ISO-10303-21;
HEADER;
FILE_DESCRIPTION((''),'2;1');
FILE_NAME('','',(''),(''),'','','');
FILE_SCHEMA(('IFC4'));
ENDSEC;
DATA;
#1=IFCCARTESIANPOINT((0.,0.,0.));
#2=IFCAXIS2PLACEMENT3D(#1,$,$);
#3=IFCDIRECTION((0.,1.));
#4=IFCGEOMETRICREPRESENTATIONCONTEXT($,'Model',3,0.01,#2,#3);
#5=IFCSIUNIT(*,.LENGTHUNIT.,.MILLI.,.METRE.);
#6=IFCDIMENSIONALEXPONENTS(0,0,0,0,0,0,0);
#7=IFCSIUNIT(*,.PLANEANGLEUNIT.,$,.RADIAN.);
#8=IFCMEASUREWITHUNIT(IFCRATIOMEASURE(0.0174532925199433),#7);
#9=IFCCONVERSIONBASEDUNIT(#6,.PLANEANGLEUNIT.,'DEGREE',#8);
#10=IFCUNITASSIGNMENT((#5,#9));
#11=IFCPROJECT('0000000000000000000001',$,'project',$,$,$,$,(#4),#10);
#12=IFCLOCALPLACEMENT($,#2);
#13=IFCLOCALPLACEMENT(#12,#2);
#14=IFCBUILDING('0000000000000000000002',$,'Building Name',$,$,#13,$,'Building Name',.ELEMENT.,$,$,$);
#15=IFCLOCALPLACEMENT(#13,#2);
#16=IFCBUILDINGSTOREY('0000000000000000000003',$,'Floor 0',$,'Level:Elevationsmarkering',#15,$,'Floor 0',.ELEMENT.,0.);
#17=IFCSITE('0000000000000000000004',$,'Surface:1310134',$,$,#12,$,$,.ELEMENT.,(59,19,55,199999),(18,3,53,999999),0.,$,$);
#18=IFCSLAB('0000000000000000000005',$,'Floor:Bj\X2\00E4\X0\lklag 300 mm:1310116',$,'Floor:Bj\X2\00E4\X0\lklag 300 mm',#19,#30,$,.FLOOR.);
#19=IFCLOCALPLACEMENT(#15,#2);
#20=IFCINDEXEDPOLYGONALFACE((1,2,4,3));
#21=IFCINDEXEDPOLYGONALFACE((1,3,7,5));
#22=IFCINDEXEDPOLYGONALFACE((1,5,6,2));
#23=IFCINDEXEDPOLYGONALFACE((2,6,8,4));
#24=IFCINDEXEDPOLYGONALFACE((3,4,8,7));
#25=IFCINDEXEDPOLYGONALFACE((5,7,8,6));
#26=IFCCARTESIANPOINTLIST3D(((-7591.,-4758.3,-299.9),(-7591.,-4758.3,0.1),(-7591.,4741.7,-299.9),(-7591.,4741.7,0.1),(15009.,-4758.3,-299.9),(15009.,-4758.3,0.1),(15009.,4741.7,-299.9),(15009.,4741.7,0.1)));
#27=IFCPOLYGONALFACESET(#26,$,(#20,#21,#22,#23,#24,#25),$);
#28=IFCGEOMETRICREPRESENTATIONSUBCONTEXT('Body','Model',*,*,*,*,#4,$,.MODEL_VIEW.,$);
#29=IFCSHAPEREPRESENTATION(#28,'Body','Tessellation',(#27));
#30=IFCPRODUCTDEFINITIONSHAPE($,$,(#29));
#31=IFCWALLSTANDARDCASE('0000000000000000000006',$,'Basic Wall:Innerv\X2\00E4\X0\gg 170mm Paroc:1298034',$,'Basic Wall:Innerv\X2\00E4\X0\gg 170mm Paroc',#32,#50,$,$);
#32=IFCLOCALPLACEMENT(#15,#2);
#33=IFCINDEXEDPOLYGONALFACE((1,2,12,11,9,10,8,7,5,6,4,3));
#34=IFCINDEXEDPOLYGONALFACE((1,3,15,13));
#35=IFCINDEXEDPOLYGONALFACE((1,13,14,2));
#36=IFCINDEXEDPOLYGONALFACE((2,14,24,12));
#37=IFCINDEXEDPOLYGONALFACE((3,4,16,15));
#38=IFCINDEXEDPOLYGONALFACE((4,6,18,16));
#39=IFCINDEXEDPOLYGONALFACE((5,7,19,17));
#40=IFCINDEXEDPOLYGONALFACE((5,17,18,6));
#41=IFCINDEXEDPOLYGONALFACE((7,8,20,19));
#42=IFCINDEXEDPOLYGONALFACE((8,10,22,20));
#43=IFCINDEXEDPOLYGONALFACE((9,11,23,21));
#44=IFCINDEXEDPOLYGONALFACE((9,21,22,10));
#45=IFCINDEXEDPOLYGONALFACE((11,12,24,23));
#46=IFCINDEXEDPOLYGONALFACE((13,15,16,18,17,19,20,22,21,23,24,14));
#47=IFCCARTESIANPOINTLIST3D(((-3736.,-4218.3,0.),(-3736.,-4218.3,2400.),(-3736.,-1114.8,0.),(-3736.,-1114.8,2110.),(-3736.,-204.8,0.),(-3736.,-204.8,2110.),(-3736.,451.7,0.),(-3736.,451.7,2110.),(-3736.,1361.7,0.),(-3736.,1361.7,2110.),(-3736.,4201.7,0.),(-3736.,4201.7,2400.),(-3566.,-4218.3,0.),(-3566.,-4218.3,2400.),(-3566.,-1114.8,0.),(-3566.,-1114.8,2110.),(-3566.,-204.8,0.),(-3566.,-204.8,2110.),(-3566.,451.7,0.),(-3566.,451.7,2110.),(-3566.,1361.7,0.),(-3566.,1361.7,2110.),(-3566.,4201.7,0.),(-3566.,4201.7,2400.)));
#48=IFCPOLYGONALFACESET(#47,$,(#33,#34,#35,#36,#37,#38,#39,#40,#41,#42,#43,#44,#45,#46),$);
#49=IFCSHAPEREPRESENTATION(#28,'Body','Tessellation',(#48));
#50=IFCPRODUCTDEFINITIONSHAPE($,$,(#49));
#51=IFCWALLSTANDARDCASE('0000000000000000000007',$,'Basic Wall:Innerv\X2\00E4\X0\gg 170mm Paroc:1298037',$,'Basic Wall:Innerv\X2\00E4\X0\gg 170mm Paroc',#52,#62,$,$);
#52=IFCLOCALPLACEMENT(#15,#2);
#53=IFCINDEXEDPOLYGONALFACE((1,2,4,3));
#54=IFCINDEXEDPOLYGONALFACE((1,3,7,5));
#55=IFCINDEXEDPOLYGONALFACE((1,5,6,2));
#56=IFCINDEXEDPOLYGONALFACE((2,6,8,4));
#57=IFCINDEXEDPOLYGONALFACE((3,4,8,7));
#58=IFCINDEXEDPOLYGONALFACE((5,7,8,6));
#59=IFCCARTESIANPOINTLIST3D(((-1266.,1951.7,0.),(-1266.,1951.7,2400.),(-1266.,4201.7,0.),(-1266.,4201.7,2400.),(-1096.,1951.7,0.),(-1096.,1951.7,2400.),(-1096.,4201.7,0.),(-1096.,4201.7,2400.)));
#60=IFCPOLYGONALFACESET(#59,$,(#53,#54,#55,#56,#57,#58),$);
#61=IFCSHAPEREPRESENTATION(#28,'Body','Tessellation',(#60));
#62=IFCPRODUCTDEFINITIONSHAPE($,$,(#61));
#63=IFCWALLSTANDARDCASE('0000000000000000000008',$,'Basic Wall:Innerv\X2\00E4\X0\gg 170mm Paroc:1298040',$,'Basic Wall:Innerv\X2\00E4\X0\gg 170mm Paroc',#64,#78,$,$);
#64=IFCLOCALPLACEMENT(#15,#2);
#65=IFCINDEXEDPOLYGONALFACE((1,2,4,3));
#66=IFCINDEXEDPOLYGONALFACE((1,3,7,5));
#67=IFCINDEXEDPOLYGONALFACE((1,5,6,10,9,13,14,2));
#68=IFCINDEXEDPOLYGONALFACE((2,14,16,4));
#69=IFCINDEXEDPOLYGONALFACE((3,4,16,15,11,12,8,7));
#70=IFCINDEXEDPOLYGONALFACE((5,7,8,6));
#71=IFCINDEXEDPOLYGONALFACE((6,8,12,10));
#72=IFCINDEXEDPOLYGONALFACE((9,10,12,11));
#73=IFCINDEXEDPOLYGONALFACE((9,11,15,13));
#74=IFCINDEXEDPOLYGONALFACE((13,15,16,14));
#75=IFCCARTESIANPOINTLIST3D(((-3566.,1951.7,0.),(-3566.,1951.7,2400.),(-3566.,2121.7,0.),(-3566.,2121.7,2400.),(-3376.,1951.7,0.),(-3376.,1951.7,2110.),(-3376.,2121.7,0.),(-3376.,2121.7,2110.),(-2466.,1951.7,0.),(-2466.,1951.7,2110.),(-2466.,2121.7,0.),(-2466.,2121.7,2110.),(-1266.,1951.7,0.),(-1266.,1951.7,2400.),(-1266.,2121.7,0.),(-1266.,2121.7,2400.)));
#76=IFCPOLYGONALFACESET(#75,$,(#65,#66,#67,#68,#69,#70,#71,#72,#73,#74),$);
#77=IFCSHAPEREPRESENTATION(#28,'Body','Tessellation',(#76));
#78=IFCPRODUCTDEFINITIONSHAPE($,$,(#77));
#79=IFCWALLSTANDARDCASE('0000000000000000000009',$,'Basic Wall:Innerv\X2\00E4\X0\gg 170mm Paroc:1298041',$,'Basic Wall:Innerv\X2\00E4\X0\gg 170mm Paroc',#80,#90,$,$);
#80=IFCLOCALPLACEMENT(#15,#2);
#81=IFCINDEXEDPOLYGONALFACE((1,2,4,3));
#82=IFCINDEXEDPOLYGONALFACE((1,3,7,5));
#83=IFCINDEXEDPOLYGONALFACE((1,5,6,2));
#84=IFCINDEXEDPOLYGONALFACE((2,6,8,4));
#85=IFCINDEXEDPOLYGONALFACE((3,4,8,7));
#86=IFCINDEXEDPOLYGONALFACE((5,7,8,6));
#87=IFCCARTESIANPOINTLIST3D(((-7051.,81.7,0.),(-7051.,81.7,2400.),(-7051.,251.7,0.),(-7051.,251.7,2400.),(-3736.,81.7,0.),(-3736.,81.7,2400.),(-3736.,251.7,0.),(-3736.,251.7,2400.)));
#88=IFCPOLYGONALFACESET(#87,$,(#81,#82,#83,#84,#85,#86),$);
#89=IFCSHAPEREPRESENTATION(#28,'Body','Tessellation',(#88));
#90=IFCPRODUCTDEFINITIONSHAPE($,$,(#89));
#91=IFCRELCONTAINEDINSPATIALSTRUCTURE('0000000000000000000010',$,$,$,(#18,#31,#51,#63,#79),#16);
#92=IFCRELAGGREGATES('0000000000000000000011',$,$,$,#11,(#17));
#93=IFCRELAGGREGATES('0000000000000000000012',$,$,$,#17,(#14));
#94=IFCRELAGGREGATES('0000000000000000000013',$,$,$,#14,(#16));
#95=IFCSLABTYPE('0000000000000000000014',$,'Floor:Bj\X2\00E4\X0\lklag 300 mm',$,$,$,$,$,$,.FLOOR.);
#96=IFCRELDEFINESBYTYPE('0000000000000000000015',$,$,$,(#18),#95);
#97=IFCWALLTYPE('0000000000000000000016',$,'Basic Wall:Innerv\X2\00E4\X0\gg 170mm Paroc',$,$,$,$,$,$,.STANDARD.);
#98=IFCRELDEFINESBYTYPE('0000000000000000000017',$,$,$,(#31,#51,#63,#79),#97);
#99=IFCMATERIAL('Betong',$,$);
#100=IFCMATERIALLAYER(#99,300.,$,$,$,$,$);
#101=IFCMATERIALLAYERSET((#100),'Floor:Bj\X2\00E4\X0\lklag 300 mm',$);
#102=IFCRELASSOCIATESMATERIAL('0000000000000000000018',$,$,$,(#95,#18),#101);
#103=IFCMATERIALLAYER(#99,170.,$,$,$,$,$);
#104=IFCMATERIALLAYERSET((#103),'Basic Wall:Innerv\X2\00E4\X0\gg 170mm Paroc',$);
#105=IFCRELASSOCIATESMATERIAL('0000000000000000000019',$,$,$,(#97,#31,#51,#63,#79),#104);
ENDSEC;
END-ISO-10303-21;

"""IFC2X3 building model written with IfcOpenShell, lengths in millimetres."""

from ifc_helpers import new_model, entity, si_unit, converted_unit, direction, frame, frame_2d, origin, place, context, subcontext, project, spatial, rectangle, extrude, material, layer, layer_set, layer_usage, type_object, element, save


model = new_model("IFC2X3")

# Units and contexts
model_context = context("Model", 3, precision=0.01, world=origin(), true_north=direction((0.0, 1.0)))
body_context = subcontext(model_context, "Body", "Model", "MODEL_VIEW")
ifc_project = project(units=[si_unit("LENGTHUNIT", "METRE", prefix="MILLI"), converted_unit("PLANEANGLEUNIT", "DEGREE", entity("IfcRatioMeasure", 0.0174532925199433), si_unit("PLANEANGLEUNIT", "RADIAN"), dimensions=[0, 0, 0, 0, 0, 0, 0])], contexts=[model_context])

# Site, building, storey
site_placement = place(None, origin())
site = spatial("IfcSite", under=ifc_project, at=site_placement, Name="Surface:1310134", CompositionType="ELEMENT", RefLatitude=(59, 19, 55, 199999), RefLongitude=(18, 3, 53, 999999), RefElevation=0.0)
building_placement = place(site_placement, origin())
building = spatial("IfcBuilding", under=site, at=building_placement, Name="Building Name", LongName="Building Name", CompositionType="ELEMENT")
storey_placement = place(building_placement, origin())
storey = spatial("IfcBuildingStorey", under=building, at=storey_placement, Name="Floor 0", ObjectType="Level:Elevationsmarkering", LongName="Floor 0", CompositionType="ELEMENT", Elevation=0.0)

# Slab
ifc_material_1 = material(Name="Betong")
ifc_layer_1 = layer(ifc_material_1, 300.0)
ifc_layer_set_1 = layer_set([ifc_layer_1], Name="Floor:Bjälklag 300 mm")
ifc_layer_usage_1 = layer_usage(ifc_layer_set_1, "AXIS3", "POSITIVE", 0.0)
slab_type = type_object("IfcSlabType", Name="Floor:Bjälklag 300 mm", PredefinedType="FLOOR", material=ifc_layer_set_1)
slab_placement = place(storey_placement, origin())
element("IfcSlab", 1, at=slab_placement, inside=storey, type_object=slab_type, material=ifc_layer_usage_1, Name="Floor:Bjälklag 300 mm:1310116", ObjectType="Floor:Bjälklag 300 mm", PredefinedType="FLOOR", context=body_context, shape_type="SweptSolid", body=[
    extrude(rectangle(XDim=9500.0, YDim=22600.0, at=frame_2d((0.0, 0.0), x_axis=(1.0, 0.0))), frame((3709.0, -8.3, 0.1), z_axis=(0.0, 0.0, -1.0), x_axis=(0.0, 1.0, 0.0)), (0.0, 0.0, 1.0), 300.0),
])

# Wall, openings
ifc_layer_2 = layer(ifc_material_1, 170.0)
ifc_layer_set_2 = layer_set([ifc_layer_2], Name="Basic Wall:Innervägg 170mm Paroc")
ifc_layer_usage_2 = layer_usage(ifc_layer_set_2, "AXIS2", "NEGATIVE", 85.0)
wall_type_1 = type_object("IfcWallType", Name="Basic Wall:Innervägg 170mm Paroc", PredefinedType="STANDARD", material=ifc_layer_set_2)
wall_1_placement = place(storey_placement, frame((-3651.0, 4201.7, 0.0), z_axis=(0.0, 0.0, 1.0), x_axis=(0.0, -1.0, 0.0)))
wall_1 = element("IfcWallStandardCase", 2, at=wall_1_placement, inside=storey, type_object=wall_type_1, material=ifc_layer_usage_2, Name="Basic Wall:Innervägg 170mm Paroc:1298034", ObjectType="Basic Wall:Innervägg 170mm Paroc", context=body_context, shape_type="SweptSolid", body=[
    extrude(rectangle(XDim=8420.0, YDim=170.0, at=frame_2d((4210.0, 0.0), x_axis=(-1.0, 0.0))), origin(), (0.0, 0.0, 1.0), 2400.0),
])
opening_1_placement = place(wall_1_placement, frame((3750.0, 85.0, 0.0)))
element("IfcOpeningElement", 3, at=opening_1_placement, cuts=wall_1, ObjectType="Opening", context=body_context, shape_type="SweptSolid", body=[
    extrude(rectangle(XDim=2110.0, YDim=910.0, at=frame_2d((1055.0, 455.0), x_axis=(1.0, 0.0))), frame((0.0, 0.0, 0.0), z_axis=(0.0, -1.0, 0.0), x_axis=(0.0, 0.0, 1.0)), (0.0, 0.0, 1.0), 170.0),
])
opening_2_placement = place(wall_1_placement, frame((5316.5, 85.0, 0.0)))
element("IfcOpeningElement", 4, at=opening_2_placement, cuts=wall_1, ObjectType="Opening", context=body_context, shape_type="SweptSolid", body=[
    extrude(rectangle(XDim=2110.0, YDim=910.0, at=frame_2d((1055.0, 455.0), x_axis=(1.0, 0.0))), frame((0.0, 0.0, 0.0), z_axis=(0.0, -1.0, 0.0), x_axis=(0.0, 0.0, 1.0)), (0.0, 0.0, 1.0), 170.0),
])

# Wall
ifc_layer_usage_3 = layer_usage(ifc_layer_set_2, "AXIS2", "NEGATIVE", 85.0)
wall_2_placement = place(storey_placement, frame((-1181.0, 1951.7, 0.0), z_axis=(0.0, 0.0, 1.0), x_axis=(0.0, 1.0, 0.0)))
element("IfcWallStandardCase", 5, at=wall_2_placement, inside=storey, type_object=wall_type_1, material=ifc_layer_usage_3, Name="Basic Wall:Innervägg 170mm Paroc:1298037", ObjectType="Basic Wall:Innervägg 170mm Paroc", context=body_context, shape_type="SweptSolid", body=[
    extrude(rectangle(XDim=2250.0, YDim=170.0, at=frame_2d((1125.0, 0.0), x_axis=(-1.0, 0.0))), origin(), (0.0, 0.0, 1.0), 2400.0),
])

# Wall, opening
ifc_layer_usage_4 = layer_usage(ifc_layer_set_2, "AXIS2", "POSITIVE", -85.0)
wall_3_placement = place(storey_placement, frame((-1266.0, 2036.7, 0.0), z_axis=(0.0, 0.0, 1.0), x_axis=(-1.0, 0.0, 0.0)))
wall_3 = element("IfcWallStandardCase", 6, at=wall_3_placement, inside=storey, type_object=wall_type_1, material=ifc_layer_usage_4, Name="Basic Wall:Innervägg 170mm Paroc:1298040", ObjectType="Basic Wall:Innervägg 170mm Paroc", context=body_context, shape_type="SweptSolid", body=[
    extrude(rectangle(XDim=2300.0, YDim=170.0, at=frame_2d((1150.0, 0.0), x_axis=(-1.0, 0.0))), origin(), (0.0, 0.0, 1.0), 2400.0),
])
opening_3_placement = place(wall_3_placement, frame((2110.0, 85.0, 0.0)))
element("IfcOpeningElement", 7, at=opening_3_placement, cuts=wall_3, ObjectType="Opening", context=body_context, shape_type="SweptSolid", body=[
    extrude(rectangle(XDim=2110.0, YDim=910.0, at=frame_2d((1055.0, 455.0), x_axis=(1.0, 0.0))), frame((0.0, 0.0, 0.0), z_axis=(0.0, -1.0, 0.0), x_axis=(0.0, 0.0, 1.0)), (0.0, 0.0, 1.0), 170.0),
])

# Wall
ifc_layer_usage_5 = layer_usage(ifc_layer_set_2, "AXIS2", "NEGATIVE", 85.0)
wall_4_placement = place(storey_placement, frame((-3736.0, 166.7, 0.0), z_axis=(0.0, 0.0, 1.0), x_axis=(-1.0, 0.0, 0.0)))
element("IfcWallStandardCase", 8, at=wall_4_placement, inside=storey, type_object=wall_type_1, material=ifc_layer_usage_5, Name="Basic Wall:Innervägg 170mm Paroc:1298041", ObjectType="Basic Wall:Innervägg 170mm Paroc", context=body_context, shape_type="SweptSolid", body=[
    extrude(rectangle(XDim=3315.0, YDim=170.0, at=frame_2d((1657.5, 0.0), x_axis=(-1.0, 0.0))), origin(), (0.0, 0.0, 1.0), 2400.0),
])

save(model, "model.ifc")
